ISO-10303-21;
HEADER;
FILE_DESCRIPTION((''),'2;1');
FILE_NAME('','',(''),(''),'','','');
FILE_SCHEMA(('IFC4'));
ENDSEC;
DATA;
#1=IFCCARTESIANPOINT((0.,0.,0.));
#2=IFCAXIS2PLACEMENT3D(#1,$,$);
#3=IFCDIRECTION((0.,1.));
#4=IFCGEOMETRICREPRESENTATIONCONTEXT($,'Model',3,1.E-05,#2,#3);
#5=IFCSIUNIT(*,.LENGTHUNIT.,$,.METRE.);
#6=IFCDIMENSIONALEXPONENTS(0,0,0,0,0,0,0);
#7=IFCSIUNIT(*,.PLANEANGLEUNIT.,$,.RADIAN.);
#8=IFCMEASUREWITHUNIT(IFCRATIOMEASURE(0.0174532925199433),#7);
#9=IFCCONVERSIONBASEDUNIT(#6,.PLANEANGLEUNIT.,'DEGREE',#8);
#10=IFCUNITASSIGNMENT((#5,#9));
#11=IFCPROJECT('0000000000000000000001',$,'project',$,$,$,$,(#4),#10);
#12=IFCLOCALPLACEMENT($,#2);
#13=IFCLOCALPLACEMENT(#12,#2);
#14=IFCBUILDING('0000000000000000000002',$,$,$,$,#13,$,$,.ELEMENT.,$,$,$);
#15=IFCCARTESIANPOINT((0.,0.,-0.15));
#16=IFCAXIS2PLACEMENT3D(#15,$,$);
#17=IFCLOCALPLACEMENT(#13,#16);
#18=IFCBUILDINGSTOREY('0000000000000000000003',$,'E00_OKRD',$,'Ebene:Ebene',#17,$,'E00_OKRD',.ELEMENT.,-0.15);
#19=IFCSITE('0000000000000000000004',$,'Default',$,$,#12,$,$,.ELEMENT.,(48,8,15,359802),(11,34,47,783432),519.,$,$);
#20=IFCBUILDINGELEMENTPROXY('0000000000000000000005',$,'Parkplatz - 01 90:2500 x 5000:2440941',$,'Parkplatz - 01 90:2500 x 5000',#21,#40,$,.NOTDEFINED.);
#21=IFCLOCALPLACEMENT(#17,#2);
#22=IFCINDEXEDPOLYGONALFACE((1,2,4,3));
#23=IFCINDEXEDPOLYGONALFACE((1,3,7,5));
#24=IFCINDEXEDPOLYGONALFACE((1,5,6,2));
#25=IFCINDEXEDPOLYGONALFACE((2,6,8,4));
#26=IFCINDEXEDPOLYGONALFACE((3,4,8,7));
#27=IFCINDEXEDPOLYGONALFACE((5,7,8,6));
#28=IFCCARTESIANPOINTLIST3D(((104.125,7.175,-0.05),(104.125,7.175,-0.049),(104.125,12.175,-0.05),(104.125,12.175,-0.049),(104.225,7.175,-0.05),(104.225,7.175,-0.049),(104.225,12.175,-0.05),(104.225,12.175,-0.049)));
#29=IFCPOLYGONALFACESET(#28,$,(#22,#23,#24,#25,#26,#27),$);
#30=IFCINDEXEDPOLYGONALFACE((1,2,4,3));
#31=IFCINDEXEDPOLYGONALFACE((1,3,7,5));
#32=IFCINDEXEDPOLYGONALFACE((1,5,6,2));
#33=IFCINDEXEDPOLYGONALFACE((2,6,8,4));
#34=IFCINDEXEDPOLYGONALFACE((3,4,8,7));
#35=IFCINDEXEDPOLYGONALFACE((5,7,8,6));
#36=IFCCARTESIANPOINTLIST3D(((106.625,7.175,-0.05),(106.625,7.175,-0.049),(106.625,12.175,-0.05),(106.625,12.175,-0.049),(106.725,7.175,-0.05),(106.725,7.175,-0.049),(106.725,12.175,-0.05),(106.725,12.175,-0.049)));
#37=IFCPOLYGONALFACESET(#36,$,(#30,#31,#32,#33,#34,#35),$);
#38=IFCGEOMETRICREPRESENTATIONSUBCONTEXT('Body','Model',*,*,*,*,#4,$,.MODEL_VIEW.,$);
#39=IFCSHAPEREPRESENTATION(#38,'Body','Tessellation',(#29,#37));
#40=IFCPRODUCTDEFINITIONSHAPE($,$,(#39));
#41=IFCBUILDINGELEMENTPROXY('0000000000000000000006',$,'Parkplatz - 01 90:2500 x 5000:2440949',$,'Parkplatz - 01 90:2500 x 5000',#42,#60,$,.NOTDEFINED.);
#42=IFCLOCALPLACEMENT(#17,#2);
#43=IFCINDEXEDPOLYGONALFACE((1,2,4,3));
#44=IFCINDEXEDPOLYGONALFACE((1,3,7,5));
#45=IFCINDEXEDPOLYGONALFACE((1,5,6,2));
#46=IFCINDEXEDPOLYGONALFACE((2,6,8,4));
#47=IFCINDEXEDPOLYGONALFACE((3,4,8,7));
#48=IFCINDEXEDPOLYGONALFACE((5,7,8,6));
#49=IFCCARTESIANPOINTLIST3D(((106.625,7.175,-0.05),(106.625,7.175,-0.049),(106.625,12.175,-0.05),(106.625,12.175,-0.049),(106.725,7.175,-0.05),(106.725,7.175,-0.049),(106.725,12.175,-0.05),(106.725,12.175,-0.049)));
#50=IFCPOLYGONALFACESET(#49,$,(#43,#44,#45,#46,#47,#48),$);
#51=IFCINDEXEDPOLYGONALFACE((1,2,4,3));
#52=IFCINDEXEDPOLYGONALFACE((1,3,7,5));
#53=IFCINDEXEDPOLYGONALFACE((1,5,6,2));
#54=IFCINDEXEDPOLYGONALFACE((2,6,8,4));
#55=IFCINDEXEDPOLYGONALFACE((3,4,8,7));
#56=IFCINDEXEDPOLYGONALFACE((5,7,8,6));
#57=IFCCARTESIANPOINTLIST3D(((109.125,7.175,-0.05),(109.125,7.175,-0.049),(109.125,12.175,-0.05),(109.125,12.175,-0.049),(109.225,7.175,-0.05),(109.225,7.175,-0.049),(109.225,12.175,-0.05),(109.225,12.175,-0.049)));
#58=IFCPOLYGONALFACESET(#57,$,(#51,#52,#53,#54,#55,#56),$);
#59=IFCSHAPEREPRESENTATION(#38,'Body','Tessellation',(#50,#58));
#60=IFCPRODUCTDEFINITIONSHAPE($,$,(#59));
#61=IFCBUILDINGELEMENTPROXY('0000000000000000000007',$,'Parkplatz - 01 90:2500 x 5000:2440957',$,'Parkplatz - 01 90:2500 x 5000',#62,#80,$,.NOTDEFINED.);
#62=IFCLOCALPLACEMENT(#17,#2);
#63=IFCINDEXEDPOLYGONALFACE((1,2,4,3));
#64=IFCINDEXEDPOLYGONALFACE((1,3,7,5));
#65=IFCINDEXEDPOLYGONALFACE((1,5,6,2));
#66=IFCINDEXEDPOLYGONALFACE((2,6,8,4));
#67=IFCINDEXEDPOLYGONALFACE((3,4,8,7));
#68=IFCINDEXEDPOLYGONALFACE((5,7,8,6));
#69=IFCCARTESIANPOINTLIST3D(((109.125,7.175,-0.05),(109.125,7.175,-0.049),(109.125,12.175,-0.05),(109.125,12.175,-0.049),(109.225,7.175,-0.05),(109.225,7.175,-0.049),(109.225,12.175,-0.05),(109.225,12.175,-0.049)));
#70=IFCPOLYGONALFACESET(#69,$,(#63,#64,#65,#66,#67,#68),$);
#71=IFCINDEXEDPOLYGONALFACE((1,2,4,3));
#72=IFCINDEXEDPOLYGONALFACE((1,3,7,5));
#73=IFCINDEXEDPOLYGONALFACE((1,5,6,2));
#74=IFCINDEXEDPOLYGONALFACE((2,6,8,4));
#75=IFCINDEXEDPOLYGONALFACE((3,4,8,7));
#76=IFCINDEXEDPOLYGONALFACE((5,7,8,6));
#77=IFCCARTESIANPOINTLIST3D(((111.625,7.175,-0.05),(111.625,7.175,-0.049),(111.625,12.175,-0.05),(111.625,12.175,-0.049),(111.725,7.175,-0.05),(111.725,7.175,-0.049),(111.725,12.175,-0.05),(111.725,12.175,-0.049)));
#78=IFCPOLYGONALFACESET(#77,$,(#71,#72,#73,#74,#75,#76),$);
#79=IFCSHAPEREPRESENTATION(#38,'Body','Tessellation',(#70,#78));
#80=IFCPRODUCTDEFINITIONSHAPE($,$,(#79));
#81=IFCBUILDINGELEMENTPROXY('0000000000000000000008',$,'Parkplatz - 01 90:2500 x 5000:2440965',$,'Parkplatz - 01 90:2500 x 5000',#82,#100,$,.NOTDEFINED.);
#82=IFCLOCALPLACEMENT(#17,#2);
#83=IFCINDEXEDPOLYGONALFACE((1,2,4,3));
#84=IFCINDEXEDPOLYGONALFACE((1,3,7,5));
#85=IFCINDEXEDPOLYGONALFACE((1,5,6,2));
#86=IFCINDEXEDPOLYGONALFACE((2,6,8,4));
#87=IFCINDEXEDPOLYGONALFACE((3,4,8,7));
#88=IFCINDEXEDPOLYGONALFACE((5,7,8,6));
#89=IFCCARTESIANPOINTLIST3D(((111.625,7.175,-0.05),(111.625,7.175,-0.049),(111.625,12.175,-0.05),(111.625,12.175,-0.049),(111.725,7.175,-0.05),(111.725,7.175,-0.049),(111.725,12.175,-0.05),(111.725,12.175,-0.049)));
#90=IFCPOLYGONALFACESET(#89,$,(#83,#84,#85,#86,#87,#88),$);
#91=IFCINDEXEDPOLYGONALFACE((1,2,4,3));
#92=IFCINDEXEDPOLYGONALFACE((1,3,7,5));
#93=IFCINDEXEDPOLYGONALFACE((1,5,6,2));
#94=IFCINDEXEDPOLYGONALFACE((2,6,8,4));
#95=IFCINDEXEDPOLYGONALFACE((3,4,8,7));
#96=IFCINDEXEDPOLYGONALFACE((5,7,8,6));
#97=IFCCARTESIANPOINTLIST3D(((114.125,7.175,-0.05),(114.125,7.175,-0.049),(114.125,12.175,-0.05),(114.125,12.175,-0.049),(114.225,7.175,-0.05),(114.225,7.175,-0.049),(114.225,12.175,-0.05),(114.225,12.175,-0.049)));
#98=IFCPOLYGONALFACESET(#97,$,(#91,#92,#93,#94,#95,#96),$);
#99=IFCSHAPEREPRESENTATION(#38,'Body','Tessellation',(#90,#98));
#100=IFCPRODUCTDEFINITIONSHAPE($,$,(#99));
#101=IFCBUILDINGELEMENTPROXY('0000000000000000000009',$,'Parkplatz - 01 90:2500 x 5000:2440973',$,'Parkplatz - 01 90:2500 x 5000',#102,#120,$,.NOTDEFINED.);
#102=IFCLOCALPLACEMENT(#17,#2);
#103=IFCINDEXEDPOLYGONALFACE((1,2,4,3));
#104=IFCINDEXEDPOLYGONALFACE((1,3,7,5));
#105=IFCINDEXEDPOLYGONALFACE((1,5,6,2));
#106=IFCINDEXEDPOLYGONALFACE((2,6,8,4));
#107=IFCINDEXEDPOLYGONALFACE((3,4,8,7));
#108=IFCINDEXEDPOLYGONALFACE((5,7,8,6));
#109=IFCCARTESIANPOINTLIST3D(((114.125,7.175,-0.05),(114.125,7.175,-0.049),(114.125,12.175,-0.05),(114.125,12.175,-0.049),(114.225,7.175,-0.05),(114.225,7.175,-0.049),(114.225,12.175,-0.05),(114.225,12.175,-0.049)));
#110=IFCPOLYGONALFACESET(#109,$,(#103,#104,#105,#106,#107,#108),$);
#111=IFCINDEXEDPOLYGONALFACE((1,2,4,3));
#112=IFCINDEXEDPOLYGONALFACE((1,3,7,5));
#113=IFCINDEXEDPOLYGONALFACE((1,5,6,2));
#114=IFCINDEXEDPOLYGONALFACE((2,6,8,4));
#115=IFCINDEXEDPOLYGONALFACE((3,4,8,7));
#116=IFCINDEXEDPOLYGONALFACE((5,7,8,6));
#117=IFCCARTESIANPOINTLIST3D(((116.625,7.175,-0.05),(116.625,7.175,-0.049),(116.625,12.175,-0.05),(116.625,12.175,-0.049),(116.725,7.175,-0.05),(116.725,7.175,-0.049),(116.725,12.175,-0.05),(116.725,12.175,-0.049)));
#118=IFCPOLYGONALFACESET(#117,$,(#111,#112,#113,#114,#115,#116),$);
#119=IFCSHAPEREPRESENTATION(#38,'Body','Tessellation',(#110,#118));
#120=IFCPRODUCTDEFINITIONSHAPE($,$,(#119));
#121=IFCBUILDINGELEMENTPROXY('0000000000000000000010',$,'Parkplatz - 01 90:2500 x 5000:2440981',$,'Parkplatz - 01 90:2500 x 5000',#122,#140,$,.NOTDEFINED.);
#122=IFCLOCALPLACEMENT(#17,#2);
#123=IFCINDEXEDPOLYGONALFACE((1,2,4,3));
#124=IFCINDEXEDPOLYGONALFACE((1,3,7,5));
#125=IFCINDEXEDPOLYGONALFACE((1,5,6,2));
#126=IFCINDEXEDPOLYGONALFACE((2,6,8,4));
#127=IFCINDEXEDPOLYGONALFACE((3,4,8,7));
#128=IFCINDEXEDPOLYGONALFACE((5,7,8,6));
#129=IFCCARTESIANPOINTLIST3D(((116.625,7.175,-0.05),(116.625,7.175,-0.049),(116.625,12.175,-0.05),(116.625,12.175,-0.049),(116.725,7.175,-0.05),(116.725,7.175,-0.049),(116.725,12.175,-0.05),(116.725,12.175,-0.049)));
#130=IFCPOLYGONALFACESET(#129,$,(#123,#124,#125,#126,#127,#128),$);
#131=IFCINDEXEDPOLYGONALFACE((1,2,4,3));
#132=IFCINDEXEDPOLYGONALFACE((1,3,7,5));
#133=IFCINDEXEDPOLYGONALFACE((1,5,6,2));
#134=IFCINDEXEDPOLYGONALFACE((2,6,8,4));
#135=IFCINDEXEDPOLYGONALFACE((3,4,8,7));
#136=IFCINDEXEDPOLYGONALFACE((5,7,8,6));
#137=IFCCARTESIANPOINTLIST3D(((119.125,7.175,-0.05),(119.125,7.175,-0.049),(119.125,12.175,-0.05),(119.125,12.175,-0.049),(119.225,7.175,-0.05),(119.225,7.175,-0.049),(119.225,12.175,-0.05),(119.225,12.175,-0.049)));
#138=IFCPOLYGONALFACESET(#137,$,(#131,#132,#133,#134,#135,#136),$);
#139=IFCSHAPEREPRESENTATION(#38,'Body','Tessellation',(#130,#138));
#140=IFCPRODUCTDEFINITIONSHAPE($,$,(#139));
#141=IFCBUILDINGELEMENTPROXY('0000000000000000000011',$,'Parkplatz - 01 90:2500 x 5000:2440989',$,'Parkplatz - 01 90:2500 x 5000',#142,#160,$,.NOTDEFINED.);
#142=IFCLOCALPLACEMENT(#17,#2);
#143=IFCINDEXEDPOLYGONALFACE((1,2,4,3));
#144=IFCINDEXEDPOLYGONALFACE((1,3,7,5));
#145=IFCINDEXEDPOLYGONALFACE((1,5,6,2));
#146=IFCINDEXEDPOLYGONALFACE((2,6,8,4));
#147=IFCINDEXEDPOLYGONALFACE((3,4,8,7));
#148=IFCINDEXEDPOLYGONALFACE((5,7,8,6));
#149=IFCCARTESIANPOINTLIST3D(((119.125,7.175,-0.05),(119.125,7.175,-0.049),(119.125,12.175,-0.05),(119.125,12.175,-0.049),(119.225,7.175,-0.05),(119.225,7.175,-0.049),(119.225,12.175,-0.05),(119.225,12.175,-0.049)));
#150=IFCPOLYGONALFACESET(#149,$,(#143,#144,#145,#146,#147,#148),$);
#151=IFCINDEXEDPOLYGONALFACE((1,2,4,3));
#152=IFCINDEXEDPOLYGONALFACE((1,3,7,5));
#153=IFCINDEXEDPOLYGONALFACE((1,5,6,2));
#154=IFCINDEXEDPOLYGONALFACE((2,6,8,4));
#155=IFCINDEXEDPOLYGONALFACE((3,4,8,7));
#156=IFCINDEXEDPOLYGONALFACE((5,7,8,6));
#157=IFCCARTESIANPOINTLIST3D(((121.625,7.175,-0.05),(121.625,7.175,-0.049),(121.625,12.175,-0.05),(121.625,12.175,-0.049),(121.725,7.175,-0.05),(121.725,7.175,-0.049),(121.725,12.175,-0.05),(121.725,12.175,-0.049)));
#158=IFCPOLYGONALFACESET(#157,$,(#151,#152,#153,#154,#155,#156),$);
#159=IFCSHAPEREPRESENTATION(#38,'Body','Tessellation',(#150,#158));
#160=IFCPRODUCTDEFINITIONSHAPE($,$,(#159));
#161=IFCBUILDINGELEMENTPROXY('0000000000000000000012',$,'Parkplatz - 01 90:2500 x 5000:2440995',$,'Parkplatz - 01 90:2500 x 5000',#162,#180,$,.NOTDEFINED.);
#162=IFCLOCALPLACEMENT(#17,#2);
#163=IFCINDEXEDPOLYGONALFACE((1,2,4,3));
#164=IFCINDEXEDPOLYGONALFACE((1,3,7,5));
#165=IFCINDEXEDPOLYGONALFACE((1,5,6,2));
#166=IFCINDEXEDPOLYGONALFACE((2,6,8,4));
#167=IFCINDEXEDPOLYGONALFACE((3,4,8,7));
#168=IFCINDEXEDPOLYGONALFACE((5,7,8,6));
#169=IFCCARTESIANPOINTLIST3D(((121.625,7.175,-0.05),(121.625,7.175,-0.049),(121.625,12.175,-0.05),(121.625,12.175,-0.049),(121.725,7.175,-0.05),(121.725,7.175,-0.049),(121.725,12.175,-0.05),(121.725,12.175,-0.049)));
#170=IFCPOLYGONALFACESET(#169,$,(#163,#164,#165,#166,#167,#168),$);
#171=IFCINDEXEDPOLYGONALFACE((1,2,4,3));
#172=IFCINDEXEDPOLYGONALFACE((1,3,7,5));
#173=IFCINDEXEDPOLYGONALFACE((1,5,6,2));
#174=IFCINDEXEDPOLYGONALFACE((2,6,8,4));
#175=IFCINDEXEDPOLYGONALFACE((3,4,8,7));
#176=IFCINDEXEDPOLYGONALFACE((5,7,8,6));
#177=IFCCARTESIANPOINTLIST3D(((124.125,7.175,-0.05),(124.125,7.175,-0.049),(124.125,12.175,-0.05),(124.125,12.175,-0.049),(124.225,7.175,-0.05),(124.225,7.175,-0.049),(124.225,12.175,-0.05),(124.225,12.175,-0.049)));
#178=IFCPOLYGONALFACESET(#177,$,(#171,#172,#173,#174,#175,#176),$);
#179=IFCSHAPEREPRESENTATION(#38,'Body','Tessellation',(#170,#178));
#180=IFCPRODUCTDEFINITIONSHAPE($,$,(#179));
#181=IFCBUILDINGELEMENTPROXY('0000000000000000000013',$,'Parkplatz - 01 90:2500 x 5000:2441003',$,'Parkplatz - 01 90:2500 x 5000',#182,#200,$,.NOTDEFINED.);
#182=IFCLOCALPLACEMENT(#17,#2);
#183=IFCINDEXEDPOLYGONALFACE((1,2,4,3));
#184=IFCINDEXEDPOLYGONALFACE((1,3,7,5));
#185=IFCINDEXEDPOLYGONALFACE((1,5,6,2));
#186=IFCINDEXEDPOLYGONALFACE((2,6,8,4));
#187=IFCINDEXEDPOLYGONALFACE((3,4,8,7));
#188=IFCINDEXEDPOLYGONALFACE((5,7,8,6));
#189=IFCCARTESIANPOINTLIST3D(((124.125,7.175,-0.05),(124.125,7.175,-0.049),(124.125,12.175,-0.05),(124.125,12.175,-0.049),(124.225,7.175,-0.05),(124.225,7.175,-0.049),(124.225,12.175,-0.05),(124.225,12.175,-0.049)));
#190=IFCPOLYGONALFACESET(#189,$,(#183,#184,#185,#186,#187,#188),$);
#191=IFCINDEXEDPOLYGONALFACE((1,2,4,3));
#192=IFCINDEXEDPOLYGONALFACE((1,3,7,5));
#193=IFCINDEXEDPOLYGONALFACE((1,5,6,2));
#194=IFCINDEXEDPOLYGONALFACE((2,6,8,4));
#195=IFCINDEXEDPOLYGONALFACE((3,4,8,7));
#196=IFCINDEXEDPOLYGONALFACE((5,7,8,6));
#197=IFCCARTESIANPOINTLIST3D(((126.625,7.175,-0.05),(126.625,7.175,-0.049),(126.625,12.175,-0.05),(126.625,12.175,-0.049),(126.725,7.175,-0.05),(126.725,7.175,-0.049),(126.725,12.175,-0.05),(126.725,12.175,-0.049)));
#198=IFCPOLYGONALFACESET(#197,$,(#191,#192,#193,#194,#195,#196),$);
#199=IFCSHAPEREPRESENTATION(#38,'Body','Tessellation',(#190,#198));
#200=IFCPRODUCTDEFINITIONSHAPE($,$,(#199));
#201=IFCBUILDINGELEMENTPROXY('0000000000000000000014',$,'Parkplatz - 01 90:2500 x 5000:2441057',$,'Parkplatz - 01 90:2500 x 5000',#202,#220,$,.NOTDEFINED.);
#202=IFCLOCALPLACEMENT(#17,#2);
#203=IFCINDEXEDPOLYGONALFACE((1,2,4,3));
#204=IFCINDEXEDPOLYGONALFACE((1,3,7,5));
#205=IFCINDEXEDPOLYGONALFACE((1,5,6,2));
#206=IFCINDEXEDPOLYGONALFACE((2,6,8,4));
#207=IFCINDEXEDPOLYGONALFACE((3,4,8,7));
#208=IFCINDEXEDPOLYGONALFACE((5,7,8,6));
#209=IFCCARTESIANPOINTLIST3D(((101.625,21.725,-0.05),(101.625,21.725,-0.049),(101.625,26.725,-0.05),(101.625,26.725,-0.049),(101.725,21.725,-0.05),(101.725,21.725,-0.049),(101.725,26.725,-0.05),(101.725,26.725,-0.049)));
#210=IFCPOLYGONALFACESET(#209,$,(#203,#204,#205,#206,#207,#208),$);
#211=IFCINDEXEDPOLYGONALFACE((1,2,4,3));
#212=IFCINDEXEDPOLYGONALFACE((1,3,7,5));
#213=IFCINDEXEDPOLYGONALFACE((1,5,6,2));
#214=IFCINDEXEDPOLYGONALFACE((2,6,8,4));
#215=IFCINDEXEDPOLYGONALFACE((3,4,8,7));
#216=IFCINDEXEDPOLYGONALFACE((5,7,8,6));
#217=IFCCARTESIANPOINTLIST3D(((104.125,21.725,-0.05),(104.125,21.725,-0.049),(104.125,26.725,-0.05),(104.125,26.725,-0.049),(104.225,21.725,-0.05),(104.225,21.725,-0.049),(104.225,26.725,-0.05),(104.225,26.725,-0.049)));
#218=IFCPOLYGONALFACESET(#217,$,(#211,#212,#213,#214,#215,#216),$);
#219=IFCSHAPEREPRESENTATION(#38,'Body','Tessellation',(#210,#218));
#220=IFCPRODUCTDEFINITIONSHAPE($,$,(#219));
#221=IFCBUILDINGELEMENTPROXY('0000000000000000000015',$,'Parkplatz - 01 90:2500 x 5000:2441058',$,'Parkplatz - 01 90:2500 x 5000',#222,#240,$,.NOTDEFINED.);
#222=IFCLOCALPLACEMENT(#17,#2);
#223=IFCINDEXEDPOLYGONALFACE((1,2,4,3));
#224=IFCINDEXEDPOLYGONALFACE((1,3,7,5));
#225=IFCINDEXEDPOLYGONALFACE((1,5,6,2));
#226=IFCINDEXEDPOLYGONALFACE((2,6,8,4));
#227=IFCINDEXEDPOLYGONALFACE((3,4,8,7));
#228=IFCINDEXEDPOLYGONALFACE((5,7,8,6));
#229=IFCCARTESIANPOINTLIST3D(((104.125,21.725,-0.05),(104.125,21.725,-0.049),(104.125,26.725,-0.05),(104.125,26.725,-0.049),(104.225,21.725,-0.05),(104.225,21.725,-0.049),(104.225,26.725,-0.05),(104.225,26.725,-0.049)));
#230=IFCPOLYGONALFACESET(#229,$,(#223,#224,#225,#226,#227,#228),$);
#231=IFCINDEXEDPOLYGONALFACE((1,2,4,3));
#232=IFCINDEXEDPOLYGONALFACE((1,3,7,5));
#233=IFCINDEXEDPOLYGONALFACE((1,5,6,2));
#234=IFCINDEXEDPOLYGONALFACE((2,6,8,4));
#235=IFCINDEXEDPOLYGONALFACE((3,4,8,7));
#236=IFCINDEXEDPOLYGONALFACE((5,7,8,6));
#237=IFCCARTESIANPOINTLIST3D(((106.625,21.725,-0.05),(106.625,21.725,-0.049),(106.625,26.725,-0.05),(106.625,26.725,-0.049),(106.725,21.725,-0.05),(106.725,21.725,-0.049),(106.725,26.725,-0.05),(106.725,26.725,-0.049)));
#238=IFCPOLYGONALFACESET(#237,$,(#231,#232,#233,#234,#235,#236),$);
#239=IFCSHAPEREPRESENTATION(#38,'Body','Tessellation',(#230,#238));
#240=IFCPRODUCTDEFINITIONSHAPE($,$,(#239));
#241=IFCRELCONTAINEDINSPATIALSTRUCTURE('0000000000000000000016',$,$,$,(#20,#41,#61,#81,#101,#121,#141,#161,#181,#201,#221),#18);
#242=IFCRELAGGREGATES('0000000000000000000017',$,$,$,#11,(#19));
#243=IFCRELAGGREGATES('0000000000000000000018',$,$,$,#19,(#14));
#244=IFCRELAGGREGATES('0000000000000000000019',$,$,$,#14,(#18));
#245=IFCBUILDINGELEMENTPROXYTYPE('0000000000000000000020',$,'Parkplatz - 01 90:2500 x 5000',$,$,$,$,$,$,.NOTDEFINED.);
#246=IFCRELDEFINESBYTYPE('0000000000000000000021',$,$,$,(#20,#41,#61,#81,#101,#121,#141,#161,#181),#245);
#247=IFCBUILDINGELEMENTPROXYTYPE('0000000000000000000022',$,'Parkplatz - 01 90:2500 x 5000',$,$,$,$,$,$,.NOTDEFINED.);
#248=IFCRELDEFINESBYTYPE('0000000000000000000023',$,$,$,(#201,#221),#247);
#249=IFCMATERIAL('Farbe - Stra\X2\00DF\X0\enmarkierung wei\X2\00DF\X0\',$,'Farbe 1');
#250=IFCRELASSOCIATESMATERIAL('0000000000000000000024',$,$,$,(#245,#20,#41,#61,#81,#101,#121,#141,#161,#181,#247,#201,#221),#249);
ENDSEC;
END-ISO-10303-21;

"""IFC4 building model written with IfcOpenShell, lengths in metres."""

from ifc_helpers import new_model, entity, si_unit, converted_unit, direction, frame, origin, origin_2d_with_axis, place, context, subcontext, project, spatial, rectangle, extrude, source, transform, mapped, material, type_object, type_shapes, element, save


model = new_model("IFC4")

# Units and contexts
model_context = context("Model", 3, precision=1e-05, world=origin(), true_north=direction((0.0, 1.0)))
body_context = subcontext(model_context, "Body", "Model", "MODEL_VIEW")
ifc_project = project(units=[si_unit("LENGTHUNIT", "METRE"), converted_unit("PLANEANGLEUNIT", "DEGREE", entity("IfcRatioMeasure", 0.0174532925199433), si_unit("PLANEANGLEUNIT", "RADIAN"), dimensions=[0, 0, 0, 0, 0, 0, 0])], contexts=[model_context])

# Site, building, storey
site_placement = place(None, frame((0.0, 0.0, 0.0)))
site = spatial("IfcSite", under=ifc_project, at=site_placement, Name="Default", CompositionType="ELEMENT", RefLatitude=(48, 8, 15, 359802), RefLongitude=(11, 34, 47, 783432), RefElevation=519.0)
building_placement = place(site_placement, origin())
building = spatial("IfcBuilding", under=site, at=building_placement, CompositionType="ELEMENT")
storey_placement = place(building_placement, frame((0.0, 0.0, -0.15)))
storey = spatial("IfcBuildingStorey", under=building, at=storey_placement, Name="E00_OKRD", ObjectType="Ebene:Ebene", LongName="E00_OKRD", CompositionType="ELEMENT", Elevation=-0.15)

# Building element proxies
ifc_material_1 = material(Name="Farbe - Straßenmarkierung weiß", Category="Farbe 1")
building_element_proxy_type_1 = type_object("IfcBuildingElementProxyType", Name="Parkplatz - 01 90:2500 x 5000", PredefinedType="NOTDEFINED", material=ifc_material_1)
shared_shape_1 = source(origin(), body_context, "Body", "SweptSolid", [
    extrude(rectangle(XDim=5.0, YDim=0.1, at=origin_2d_with_axis()), frame((2.5456, -2.5, 0.0), z_axis=(0.0, 0.0, 1.0), x_axis=(0.0, -1.0, 0.0)), (0.0, 0.0, 1.0), 0.001),
    extrude(rectangle(XDim=0.1, YDim=5.0, at=origin_2d_with_axis()), frame((0.0456, -2.5, 0.0), z_axis=(0.0, 0.0, 1.0), x_axis=(-1.0, 0.0, 0.0)), (0.0, 0.0, 1.0), 0.001),
])
type_shapes(building_element_proxy_type_1, [shared_shape_1])
for number, where, z_axis, x_axis, name in (
    (1, (106.7206, 7.175, -0.05), (0.0, 0.0, 1.0), (-1.0, 0.0, 0.0), "Parkplatz - 01 90:2500 x 5000:2440941"),
    (2, (109.2206, 7.175, -0.05), (0.0, 0.0, 1.0), (-1.0, 0.0, 0.0), "Parkplatz - 01 90:2500 x 5000:2440949"),
    (3, (111.7206, 7.175, -0.05), (0.0, 0.0, 1.0), (-1.0, 0.0, 0.0), "Parkplatz - 01 90:2500 x 5000:2440957"),
    (4, (114.2206, 7.175, -0.05), (0.0, 0.0, 1.0), (-1.0, 0.0, 0.0), "Parkplatz - 01 90:2500 x 5000:2440965"),
    (5, (116.7206, 7.175, -0.05), (0.0, 0.0, 1.0), (-1.0, 0.0, 0.0), "Parkplatz - 01 90:2500 x 5000:2440973"),
    (6, (119.2206, 7.175, -0.05), (0.0, 0.0, 1.0), (-1.0, 0.0, 0.0), "Parkplatz - 01 90:2500 x 5000:2440981"),
    (7, (121.7206, 7.175, -0.05), (0.0, 0.0, 1.0), (-1.0, 0.0, 0.0), "Parkplatz - 01 90:2500 x 5000:2440989"),
    (8, (124.2206, 7.175, -0.05), (0.0, 0.0, 1.0), (-1.0, 0.0, 0.0), "Parkplatz - 01 90:2500 x 5000:2440995"),
    (9, (126.7206, 7.175, -0.05), (0.0, 0.0, 1.0), (-1.0, 0.0, 0.0), "Parkplatz - 01 90:2500 x 5000:2441003"),
):
    element("IfcBuildingElementProxy", number, at=place(storey_placement, frame(where, z_axis=z_axis, x_axis=x_axis)), inside=storey, type_object=building_element_proxy_type_1, material=ifc_material_1, Name=name, ObjectType="Parkplatz - 01 90:2500 x 5000", PredefinedType="NOTDEFINED", context=body_context, shape_type="MappedRepresentation", body=[
        mapped(shared_shape_1, transform((0.0, 0.0, 0.0), scale=1.0)),
    ])
building_element_proxy_type_2 = type_object("IfcBuildingElementProxyType", Name="Parkplatz - 01 90:2500 x 5000", PredefinedType="NOTDEFINED", material=ifc_material_1)
shared_shape_2 = source(origin(), body_context, "Body", "SweptSolid", [
    extrude(rectangle(XDim=0.1, YDim=5.0, at=origin_2d_with_axis()), frame((2.5456, 2.5, 0.0)), (0.0, 0.0, 1.0), 0.001),
    extrude(rectangle(XDim=5.0, YDim=0.1, at=origin_2d_with_axis()), frame((0.0456, 2.5, 0.0), z_axis=(0.0, 0.0, 1.0), x_axis=(0.0, 1.0, 0.0)), (0.0, 0.0, 1.0), 0.001),
])
type_shapes(building_element_proxy_type_2, [shared_shape_2])
for number, where, z_axis, x_axis, name in (
    (10, (104.2206, 26.725, -0.05), (0.0, 0.0, 1.0), (-1.0, 0.0, 0.0), "Parkplatz - 01 90:2500 x 5000:2441057"),
    (11, (106.7206, 26.725, -0.05), (0.0, 0.0, 1.0), (-1.0, 0.0, 0.0), "Parkplatz - 01 90:2500 x 5000:2441058"),
):
    element("IfcBuildingElementProxy", number, at=place(storey_placement, frame(where, z_axis=z_axis, x_axis=x_axis)), inside=storey, type_object=building_element_proxy_type_2, material=ifc_material_1, Name=name, ObjectType="Parkplatz - 01 90:2500 x 5000", PredefinedType="NOTDEFINED", context=body_context, shape_type="MappedRepresentation", body=[
        mapped(shared_shape_2, transform((0.0, 0.0, 0.0), scale=1.0)),
    ])

save(model, "model.ifc")
